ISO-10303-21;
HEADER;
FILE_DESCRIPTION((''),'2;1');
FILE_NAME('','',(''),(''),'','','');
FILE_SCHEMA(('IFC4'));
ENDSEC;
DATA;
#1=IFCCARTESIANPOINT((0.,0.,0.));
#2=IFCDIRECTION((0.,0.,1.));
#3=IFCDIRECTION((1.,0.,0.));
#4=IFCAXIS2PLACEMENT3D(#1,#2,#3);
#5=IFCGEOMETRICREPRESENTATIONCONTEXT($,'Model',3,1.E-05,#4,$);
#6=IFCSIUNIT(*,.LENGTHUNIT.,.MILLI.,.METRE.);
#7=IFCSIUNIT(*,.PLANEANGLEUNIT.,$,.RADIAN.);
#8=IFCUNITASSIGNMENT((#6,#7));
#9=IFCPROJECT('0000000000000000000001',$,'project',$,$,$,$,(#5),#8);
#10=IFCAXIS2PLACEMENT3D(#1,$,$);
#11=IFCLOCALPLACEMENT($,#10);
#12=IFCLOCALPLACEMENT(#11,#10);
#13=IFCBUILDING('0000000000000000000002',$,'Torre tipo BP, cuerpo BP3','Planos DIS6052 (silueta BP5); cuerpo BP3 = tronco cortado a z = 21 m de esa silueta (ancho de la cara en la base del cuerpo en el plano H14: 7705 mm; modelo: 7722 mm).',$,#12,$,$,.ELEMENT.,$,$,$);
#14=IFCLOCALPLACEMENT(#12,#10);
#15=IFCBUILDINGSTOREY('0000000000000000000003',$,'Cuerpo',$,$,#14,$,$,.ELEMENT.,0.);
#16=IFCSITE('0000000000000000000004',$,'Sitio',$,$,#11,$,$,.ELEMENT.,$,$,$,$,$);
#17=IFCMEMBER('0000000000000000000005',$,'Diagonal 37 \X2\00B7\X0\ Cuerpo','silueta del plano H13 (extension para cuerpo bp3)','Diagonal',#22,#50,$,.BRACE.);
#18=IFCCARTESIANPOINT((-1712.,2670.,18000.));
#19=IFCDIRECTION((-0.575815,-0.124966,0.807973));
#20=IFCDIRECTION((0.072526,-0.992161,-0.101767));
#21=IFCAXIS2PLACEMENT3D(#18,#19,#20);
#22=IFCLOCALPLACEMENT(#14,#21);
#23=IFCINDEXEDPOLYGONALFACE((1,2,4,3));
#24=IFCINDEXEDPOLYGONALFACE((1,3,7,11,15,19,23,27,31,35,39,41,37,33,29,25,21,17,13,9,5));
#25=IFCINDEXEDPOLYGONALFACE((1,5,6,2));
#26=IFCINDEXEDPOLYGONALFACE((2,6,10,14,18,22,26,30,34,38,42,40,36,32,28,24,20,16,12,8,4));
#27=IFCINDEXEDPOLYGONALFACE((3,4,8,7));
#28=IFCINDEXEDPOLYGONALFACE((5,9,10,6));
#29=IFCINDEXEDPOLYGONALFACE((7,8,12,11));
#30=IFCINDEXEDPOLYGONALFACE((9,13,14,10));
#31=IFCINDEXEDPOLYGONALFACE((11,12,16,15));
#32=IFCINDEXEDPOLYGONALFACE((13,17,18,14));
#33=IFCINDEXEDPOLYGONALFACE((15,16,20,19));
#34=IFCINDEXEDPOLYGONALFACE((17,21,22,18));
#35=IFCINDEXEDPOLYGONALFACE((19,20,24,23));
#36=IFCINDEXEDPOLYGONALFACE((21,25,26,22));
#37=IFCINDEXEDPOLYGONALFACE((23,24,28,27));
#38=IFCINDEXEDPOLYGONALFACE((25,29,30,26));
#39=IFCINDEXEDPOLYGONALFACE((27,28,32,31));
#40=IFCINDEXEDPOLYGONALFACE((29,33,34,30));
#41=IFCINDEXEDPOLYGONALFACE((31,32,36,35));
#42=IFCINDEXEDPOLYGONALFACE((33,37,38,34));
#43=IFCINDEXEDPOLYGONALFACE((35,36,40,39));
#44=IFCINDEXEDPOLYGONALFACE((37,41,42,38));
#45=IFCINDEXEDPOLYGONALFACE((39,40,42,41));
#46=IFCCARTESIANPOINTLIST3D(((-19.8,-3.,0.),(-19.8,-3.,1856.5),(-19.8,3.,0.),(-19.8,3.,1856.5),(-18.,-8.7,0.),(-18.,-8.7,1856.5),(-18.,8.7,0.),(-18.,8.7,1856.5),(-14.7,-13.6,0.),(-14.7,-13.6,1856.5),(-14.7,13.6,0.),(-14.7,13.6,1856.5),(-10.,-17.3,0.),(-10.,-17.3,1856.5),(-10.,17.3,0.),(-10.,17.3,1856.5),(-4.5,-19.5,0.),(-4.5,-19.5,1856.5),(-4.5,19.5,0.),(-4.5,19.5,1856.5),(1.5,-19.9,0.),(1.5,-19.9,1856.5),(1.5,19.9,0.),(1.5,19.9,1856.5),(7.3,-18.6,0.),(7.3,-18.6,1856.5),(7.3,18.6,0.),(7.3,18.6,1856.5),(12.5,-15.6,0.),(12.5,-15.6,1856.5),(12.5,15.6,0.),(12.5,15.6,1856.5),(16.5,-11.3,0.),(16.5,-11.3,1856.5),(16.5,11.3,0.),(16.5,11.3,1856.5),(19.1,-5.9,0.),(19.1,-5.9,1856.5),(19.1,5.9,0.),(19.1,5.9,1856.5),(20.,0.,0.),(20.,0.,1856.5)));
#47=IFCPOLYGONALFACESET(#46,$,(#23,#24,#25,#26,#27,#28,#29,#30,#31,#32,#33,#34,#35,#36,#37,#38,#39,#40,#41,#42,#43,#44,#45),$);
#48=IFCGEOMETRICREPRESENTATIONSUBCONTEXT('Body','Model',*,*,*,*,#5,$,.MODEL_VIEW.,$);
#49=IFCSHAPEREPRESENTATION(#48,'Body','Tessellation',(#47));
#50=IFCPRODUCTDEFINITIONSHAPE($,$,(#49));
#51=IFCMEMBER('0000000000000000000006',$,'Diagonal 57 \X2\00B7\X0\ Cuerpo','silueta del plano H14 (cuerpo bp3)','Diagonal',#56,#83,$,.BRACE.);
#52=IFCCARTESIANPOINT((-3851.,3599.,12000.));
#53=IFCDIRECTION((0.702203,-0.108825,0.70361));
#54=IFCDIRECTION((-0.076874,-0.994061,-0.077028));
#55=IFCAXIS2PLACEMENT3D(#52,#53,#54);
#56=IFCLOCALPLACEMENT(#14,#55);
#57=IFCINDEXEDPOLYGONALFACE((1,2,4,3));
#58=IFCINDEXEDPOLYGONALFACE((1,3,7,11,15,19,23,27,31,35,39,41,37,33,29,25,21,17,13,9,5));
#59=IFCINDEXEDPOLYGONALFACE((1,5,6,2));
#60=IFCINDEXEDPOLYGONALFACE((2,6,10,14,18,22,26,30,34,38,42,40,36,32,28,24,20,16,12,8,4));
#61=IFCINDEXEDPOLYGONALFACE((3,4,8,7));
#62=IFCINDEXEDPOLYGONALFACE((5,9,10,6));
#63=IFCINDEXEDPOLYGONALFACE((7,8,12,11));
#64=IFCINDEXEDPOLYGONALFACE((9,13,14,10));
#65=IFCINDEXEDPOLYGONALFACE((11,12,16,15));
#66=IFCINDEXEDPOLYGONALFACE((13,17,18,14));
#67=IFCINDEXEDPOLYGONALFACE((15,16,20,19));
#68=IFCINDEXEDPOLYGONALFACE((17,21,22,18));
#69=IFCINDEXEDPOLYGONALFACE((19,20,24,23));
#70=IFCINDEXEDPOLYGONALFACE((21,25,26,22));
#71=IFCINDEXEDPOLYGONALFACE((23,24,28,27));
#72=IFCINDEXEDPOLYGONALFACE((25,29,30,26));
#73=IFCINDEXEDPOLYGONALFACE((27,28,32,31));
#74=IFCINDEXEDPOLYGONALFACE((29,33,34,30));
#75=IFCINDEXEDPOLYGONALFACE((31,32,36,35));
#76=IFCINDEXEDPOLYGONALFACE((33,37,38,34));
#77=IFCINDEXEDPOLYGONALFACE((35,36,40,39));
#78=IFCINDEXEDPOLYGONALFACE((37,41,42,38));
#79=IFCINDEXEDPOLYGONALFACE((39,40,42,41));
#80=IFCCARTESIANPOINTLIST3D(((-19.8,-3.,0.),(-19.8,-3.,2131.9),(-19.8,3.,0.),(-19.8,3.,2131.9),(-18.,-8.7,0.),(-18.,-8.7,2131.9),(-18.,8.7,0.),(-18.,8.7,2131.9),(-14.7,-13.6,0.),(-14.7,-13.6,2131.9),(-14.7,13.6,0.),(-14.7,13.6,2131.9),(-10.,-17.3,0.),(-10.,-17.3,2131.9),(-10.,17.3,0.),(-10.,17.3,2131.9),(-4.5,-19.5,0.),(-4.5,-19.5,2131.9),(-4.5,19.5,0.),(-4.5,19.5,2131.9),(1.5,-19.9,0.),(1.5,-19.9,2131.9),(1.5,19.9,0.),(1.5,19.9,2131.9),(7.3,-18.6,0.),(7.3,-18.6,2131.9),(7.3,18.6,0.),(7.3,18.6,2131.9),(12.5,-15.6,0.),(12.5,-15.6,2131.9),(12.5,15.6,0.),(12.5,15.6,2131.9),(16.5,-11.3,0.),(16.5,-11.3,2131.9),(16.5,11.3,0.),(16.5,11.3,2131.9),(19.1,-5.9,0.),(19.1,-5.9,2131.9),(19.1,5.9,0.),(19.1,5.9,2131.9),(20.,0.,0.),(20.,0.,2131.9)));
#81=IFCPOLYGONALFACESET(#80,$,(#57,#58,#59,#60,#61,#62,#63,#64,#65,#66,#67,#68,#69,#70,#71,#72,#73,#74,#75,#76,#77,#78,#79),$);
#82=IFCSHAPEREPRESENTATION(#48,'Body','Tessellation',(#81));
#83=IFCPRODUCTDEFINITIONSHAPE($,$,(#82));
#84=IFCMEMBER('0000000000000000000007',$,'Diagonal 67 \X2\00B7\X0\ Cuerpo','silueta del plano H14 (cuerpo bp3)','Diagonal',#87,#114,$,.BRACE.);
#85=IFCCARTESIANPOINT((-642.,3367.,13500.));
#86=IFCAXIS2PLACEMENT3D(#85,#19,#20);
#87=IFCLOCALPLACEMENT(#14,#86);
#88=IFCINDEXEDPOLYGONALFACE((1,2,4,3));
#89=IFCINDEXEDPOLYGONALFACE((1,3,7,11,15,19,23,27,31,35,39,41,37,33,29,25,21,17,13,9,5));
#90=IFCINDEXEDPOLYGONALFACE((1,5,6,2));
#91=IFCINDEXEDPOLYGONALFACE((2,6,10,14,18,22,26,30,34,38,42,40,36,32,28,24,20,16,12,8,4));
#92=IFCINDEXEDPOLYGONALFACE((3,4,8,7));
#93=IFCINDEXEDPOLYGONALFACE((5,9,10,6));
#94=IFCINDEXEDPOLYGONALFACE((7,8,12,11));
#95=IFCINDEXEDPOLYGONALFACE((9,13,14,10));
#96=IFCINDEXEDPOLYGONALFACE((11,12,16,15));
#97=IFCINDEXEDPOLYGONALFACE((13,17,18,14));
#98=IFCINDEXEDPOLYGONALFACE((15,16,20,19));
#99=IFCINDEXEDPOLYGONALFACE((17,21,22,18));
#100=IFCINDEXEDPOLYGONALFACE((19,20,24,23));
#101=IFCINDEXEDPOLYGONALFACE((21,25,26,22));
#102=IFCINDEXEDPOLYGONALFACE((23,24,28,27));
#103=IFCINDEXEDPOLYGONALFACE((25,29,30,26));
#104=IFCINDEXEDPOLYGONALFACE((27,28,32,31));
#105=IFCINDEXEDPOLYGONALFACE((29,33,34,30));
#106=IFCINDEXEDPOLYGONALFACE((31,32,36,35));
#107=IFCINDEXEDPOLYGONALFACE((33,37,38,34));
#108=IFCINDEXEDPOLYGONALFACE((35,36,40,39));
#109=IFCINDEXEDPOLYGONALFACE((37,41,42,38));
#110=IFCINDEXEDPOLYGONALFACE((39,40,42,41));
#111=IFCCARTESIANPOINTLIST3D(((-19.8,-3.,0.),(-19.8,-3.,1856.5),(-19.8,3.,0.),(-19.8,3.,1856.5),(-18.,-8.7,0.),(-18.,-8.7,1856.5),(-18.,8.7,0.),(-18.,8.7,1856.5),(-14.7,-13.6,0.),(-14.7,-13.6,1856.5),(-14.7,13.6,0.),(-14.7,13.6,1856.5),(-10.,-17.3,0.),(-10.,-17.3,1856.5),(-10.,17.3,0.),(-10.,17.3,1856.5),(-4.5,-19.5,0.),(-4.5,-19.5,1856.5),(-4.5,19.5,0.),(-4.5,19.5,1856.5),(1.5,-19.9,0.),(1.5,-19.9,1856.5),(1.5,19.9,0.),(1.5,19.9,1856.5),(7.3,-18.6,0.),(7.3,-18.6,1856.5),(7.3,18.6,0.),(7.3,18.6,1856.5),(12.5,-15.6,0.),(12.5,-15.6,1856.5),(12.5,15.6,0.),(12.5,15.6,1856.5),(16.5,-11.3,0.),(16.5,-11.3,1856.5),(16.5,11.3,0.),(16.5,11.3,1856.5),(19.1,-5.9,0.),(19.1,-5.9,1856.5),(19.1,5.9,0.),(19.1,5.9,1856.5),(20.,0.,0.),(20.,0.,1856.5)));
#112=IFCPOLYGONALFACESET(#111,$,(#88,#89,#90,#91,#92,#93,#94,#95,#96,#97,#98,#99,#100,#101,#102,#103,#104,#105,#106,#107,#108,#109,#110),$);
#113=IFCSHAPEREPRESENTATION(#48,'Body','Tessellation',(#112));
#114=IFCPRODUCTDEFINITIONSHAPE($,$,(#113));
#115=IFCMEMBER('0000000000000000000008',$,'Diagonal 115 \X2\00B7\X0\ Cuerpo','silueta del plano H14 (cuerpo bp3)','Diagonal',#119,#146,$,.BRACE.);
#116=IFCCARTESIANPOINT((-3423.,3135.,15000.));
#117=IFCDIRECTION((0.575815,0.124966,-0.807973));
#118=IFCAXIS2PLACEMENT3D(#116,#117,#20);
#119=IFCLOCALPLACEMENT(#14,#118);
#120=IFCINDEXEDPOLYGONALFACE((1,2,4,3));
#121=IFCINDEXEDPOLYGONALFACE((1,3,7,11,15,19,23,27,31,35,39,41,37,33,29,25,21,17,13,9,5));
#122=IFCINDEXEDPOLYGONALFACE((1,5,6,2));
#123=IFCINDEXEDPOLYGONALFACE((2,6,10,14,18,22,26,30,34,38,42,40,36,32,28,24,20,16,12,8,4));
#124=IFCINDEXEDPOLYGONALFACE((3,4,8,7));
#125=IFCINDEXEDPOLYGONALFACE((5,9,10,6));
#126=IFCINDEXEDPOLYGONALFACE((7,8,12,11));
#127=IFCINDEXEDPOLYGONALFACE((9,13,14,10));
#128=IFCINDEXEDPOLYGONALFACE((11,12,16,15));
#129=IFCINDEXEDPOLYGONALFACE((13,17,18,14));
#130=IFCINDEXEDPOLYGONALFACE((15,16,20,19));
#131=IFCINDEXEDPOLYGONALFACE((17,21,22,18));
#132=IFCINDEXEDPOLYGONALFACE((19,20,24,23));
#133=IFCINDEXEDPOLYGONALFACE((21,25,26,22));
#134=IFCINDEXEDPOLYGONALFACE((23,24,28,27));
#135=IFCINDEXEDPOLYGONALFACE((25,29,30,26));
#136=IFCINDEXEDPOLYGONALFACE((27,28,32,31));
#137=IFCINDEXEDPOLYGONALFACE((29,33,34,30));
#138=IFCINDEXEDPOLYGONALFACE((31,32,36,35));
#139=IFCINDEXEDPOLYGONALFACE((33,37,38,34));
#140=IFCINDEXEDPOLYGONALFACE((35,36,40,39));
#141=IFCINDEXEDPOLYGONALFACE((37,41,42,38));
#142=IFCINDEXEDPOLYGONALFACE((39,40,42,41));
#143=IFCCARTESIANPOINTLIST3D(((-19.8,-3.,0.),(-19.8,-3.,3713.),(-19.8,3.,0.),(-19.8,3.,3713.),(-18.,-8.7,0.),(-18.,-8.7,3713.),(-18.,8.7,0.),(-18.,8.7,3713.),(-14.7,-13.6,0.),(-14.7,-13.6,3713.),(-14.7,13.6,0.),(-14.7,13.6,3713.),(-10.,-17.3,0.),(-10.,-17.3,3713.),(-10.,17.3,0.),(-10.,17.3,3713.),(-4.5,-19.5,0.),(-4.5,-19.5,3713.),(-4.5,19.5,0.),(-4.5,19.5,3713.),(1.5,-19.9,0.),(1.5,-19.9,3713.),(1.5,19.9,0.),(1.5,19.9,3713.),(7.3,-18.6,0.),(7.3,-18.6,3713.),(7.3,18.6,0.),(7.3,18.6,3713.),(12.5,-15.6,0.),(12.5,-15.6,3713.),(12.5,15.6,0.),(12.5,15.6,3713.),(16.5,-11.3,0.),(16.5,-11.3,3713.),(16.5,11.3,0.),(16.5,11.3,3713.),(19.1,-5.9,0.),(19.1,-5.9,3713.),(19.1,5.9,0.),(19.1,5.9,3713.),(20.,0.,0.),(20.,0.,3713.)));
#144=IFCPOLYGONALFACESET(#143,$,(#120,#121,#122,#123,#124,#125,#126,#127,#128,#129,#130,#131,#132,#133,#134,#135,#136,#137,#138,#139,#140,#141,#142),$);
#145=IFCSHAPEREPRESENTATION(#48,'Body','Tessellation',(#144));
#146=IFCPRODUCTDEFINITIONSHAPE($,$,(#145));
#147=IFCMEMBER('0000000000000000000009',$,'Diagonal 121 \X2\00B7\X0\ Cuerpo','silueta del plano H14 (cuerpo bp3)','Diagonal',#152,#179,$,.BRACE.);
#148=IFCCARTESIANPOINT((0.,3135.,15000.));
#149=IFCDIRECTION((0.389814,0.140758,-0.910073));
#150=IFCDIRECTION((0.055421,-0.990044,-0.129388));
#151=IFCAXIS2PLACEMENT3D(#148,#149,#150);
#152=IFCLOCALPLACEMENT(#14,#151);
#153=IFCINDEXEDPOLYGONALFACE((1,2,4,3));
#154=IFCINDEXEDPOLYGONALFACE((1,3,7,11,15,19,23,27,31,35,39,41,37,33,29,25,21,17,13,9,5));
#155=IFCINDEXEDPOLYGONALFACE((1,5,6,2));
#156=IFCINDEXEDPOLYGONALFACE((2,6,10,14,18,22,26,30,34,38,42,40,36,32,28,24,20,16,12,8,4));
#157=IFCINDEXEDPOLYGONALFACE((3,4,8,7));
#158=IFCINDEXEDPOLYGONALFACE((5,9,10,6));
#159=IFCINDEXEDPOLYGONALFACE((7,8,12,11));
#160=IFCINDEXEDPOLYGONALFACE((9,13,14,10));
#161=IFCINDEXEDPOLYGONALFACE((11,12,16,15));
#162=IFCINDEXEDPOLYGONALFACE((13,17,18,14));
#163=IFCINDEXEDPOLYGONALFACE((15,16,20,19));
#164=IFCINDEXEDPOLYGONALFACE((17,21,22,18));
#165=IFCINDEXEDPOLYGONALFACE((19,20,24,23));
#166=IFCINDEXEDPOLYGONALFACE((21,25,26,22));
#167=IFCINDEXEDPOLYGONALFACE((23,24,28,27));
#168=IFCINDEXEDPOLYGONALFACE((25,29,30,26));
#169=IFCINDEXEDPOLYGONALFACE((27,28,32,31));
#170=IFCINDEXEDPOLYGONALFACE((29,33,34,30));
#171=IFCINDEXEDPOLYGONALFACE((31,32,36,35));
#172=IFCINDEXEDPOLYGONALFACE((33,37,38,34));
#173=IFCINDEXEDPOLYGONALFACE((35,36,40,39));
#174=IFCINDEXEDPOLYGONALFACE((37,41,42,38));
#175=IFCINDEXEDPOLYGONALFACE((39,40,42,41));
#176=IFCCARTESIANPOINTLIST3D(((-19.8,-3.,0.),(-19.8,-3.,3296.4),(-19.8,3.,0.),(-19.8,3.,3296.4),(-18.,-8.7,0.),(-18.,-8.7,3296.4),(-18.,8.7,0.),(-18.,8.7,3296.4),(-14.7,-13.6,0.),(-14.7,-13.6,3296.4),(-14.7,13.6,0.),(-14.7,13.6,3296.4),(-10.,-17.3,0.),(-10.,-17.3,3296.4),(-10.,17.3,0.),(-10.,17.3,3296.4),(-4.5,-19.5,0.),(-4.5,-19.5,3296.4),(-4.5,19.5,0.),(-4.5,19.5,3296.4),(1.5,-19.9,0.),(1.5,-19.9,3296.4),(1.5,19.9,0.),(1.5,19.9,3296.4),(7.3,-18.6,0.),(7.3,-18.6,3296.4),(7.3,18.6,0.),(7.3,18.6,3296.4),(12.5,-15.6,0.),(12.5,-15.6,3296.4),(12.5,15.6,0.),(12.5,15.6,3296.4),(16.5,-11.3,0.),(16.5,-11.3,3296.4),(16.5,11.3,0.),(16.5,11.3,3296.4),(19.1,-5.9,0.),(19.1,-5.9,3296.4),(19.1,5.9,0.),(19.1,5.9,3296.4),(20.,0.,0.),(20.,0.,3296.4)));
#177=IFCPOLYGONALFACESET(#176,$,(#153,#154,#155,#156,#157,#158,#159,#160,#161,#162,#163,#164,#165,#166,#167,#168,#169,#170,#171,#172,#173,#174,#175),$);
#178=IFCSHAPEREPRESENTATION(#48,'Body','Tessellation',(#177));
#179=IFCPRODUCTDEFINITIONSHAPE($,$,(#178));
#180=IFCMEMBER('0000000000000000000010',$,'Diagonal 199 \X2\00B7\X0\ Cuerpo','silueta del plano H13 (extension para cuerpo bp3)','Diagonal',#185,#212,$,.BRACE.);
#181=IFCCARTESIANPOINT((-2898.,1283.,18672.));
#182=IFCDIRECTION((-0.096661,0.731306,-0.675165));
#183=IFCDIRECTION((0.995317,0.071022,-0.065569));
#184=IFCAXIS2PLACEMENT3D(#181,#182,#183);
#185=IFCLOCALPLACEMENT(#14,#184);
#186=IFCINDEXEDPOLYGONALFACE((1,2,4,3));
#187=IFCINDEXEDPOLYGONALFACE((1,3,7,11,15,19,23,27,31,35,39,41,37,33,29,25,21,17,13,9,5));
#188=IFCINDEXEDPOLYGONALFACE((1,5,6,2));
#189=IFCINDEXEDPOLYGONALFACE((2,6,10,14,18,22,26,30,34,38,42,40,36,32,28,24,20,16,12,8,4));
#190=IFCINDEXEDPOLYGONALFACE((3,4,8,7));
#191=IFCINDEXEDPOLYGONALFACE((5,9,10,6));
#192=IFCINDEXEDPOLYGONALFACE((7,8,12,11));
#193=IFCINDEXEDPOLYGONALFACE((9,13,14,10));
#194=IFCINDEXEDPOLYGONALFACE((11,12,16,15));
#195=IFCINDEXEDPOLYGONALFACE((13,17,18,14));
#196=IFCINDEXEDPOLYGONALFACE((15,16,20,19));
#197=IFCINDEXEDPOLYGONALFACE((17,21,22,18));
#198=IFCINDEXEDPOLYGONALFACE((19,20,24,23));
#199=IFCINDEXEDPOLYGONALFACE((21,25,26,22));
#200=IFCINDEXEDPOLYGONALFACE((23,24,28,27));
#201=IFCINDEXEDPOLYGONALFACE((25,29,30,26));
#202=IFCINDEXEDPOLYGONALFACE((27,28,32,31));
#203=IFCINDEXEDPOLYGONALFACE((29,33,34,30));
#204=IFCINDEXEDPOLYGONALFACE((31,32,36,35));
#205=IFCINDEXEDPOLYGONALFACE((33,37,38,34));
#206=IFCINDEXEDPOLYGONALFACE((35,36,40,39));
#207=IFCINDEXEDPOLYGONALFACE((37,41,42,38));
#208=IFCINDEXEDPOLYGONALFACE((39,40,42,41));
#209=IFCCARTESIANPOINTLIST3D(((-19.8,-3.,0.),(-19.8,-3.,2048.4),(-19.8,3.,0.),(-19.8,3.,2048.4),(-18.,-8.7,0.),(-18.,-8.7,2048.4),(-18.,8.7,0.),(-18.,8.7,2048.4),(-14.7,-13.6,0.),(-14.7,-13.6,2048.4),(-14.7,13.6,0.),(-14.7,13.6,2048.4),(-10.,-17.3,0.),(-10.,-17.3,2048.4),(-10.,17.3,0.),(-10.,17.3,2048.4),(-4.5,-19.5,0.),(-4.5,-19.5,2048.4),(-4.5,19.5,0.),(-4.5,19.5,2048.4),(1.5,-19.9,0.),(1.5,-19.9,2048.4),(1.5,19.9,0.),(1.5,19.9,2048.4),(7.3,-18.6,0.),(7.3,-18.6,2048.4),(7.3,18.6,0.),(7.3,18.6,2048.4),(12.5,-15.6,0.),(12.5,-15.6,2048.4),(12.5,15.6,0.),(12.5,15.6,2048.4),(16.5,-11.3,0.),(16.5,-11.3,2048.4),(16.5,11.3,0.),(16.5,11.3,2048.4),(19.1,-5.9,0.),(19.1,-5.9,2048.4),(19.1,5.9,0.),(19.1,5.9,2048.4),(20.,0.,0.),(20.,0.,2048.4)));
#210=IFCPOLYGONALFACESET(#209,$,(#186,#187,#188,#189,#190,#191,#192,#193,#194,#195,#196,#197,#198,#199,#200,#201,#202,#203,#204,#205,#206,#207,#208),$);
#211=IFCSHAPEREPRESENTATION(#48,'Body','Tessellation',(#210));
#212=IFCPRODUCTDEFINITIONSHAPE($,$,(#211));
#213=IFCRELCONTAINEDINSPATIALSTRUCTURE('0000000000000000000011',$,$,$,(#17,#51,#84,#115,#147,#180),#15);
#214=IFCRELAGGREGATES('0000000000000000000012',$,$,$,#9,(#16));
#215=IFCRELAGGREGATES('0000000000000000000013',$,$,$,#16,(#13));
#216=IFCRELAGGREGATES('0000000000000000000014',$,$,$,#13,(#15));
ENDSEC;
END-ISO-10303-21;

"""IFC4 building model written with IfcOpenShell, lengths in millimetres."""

from ifc_helpers import new_model, si_unit, frame, origin, origin_with_axes, place, context, subcontext, project, spatial, circle, extrude, element, save


model = new_model("IFC4")

# Units and contexts
model_context = context("Model", 3, precision=1e-05, world=origin_with_axes())
body_context = subcontext(model_context, "Body", "Model", "MODEL_VIEW")
ifc_project = project(units=[si_unit("LENGTHUNIT", "METRE", prefix="MILLI"), si_unit("PLANEANGLEUNIT", "RADIAN")], contexts=[model_context])

# Site, building, storey
site_placement = place(None, origin())
site = spatial("IfcSite", under=ifc_project, at=site_placement, Name="Sitio", CompositionType="ELEMENT")
building_placement = place(site_placement, origin())
building = spatial("IfcBuilding", under=site, at=building_placement, Name="Torre tipo BP, cuerpo BP3", Description="Planos DIS6052 (silueta BP5); cuerpo BP3 = tronco cortado a z = 21 m de esa silueta (ancho de la cara en la base del cuerpo en el plano H14: 7705 mm; modelo: 7722 mm).", CompositionType="ELEMENT")
storey_placement = place(building_placement, origin())
storey = spatial("IfcBuildingStorey", under=building, at=storey_placement, Name="Cuerpo", CompositionType="ELEMENT", Elevation=0.0)

# Members
member_1_placement = place(storey_placement, frame((-1712.0, 2670.0, 18000.0), z_axis=(-0.575815, -0.124966, 0.807973), x_axis=(0.072526, -0.992161, -0.101767)))
element("IfcMember", 1, at=member_1_placement, inside=storey, Name="Diagonal 37 · Cuerpo", Description="silueta del plano H13 (extension para cuerpo bp3)", ObjectType="Diagonal", PredefinedType="BRACE", context=body_context, shape_type="SweptSolid", body=[
    extrude(circle(Radius=20.0), None, (0.0, 0.0, 1.0), 1856.5),
])
member_2_placement = place(storey_placement, frame((-3851.0, 3599.0, 12000.0), z_axis=(0.702203, -0.108825, 0.70361), x_axis=(-0.076874, -0.994061, -0.077028)))
element("IfcMember", 2, at=member_2_placement, inside=storey, Name="Diagonal 57 · Cuerpo", Description="silueta del plano H14 (cuerpo bp3)", ObjectType="Diagonal", PredefinedType="BRACE", context=body_context, shape_type="SweptSolid", body=[
    extrude(circle(Radius=20.0), None, (0.0, 0.0, 1.0), 2131.9),
])
member_3_placement = place(storey_placement, frame((-642.0, 3367.0, 13500.0), z_axis=(-0.575815, -0.124966, 0.807973), x_axis=(0.072526, -0.992161, -0.101767)))
element("IfcMember", 3, at=member_3_placement, inside=storey, Name="Diagonal 67 · Cuerpo", Description="silueta del plano H14 (cuerpo bp3)", ObjectType="Diagonal", PredefinedType="BRACE", context=body_context, shape_type="SweptSolid", body=[
    extrude(circle(Radius=20.0), None, (0.0, 0.0, 1.0), 1856.5),
])
member_4_placement = place(storey_placement, frame((-3423.0, 3135.0, 15000.0), z_axis=(0.575815, 0.124966, -0.807973), x_axis=(0.072526, -0.992161, -0.101767)))
element("IfcMember", 4, at=member_4_placement, inside=storey, Name="Diagonal 115 · Cuerpo", Description="silueta del plano H14 (cuerpo bp3)", ObjectType="Diagonal", PredefinedType="BRACE", context=body_context, shape_type="SweptSolid", body=[
    extrude(circle(Radius=20.0), None, (0.0, 0.0, 1.0), 3713.0),
])
member_5_placement = place(storey_placement, frame((0.0, 3135.0, 15000.0), z_axis=(0.389814, 0.140758, -0.910073), x_axis=(0.055421, -0.990044, -0.129388)))
element("IfcMember", 5, at=member_5_placement, inside=storey, Name="Diagonal 121 · Cuerpo", Description="silueta del plano H14 (cuerpo bp3)", ObjectType="Diagonal", PredefinedType="BRACE", context=body_context, shape_type="SweptSolid", body=[
    extrude(circle(Radius=20.0), None, (0.0, 0.0, 1.0), 3296.4),
])
member_6_placement = place(storey_placement, frame((-2898.0, 1283.0, 18672.0), z_axis=(-0.096661, 0.731306, -0.675165), x_axis=(0.995317, 0.071022, -0.065569)))
element("IfcMember", 6, at=member_6_placement, inside=storey, Name="Diagonal 199 · Cuerpo", Description="silueta del plano H13 (extension para cuerpo bp3)", ObjectType="Diagonal", PredefinedType="BRACE", context=body_context, shape_type="SweptSolid", body=[
    extrude(circle(Radius=20.0), None, (0.0, 0.0, 1.0), 2048.4),
])

save(model, "model.ifc")
